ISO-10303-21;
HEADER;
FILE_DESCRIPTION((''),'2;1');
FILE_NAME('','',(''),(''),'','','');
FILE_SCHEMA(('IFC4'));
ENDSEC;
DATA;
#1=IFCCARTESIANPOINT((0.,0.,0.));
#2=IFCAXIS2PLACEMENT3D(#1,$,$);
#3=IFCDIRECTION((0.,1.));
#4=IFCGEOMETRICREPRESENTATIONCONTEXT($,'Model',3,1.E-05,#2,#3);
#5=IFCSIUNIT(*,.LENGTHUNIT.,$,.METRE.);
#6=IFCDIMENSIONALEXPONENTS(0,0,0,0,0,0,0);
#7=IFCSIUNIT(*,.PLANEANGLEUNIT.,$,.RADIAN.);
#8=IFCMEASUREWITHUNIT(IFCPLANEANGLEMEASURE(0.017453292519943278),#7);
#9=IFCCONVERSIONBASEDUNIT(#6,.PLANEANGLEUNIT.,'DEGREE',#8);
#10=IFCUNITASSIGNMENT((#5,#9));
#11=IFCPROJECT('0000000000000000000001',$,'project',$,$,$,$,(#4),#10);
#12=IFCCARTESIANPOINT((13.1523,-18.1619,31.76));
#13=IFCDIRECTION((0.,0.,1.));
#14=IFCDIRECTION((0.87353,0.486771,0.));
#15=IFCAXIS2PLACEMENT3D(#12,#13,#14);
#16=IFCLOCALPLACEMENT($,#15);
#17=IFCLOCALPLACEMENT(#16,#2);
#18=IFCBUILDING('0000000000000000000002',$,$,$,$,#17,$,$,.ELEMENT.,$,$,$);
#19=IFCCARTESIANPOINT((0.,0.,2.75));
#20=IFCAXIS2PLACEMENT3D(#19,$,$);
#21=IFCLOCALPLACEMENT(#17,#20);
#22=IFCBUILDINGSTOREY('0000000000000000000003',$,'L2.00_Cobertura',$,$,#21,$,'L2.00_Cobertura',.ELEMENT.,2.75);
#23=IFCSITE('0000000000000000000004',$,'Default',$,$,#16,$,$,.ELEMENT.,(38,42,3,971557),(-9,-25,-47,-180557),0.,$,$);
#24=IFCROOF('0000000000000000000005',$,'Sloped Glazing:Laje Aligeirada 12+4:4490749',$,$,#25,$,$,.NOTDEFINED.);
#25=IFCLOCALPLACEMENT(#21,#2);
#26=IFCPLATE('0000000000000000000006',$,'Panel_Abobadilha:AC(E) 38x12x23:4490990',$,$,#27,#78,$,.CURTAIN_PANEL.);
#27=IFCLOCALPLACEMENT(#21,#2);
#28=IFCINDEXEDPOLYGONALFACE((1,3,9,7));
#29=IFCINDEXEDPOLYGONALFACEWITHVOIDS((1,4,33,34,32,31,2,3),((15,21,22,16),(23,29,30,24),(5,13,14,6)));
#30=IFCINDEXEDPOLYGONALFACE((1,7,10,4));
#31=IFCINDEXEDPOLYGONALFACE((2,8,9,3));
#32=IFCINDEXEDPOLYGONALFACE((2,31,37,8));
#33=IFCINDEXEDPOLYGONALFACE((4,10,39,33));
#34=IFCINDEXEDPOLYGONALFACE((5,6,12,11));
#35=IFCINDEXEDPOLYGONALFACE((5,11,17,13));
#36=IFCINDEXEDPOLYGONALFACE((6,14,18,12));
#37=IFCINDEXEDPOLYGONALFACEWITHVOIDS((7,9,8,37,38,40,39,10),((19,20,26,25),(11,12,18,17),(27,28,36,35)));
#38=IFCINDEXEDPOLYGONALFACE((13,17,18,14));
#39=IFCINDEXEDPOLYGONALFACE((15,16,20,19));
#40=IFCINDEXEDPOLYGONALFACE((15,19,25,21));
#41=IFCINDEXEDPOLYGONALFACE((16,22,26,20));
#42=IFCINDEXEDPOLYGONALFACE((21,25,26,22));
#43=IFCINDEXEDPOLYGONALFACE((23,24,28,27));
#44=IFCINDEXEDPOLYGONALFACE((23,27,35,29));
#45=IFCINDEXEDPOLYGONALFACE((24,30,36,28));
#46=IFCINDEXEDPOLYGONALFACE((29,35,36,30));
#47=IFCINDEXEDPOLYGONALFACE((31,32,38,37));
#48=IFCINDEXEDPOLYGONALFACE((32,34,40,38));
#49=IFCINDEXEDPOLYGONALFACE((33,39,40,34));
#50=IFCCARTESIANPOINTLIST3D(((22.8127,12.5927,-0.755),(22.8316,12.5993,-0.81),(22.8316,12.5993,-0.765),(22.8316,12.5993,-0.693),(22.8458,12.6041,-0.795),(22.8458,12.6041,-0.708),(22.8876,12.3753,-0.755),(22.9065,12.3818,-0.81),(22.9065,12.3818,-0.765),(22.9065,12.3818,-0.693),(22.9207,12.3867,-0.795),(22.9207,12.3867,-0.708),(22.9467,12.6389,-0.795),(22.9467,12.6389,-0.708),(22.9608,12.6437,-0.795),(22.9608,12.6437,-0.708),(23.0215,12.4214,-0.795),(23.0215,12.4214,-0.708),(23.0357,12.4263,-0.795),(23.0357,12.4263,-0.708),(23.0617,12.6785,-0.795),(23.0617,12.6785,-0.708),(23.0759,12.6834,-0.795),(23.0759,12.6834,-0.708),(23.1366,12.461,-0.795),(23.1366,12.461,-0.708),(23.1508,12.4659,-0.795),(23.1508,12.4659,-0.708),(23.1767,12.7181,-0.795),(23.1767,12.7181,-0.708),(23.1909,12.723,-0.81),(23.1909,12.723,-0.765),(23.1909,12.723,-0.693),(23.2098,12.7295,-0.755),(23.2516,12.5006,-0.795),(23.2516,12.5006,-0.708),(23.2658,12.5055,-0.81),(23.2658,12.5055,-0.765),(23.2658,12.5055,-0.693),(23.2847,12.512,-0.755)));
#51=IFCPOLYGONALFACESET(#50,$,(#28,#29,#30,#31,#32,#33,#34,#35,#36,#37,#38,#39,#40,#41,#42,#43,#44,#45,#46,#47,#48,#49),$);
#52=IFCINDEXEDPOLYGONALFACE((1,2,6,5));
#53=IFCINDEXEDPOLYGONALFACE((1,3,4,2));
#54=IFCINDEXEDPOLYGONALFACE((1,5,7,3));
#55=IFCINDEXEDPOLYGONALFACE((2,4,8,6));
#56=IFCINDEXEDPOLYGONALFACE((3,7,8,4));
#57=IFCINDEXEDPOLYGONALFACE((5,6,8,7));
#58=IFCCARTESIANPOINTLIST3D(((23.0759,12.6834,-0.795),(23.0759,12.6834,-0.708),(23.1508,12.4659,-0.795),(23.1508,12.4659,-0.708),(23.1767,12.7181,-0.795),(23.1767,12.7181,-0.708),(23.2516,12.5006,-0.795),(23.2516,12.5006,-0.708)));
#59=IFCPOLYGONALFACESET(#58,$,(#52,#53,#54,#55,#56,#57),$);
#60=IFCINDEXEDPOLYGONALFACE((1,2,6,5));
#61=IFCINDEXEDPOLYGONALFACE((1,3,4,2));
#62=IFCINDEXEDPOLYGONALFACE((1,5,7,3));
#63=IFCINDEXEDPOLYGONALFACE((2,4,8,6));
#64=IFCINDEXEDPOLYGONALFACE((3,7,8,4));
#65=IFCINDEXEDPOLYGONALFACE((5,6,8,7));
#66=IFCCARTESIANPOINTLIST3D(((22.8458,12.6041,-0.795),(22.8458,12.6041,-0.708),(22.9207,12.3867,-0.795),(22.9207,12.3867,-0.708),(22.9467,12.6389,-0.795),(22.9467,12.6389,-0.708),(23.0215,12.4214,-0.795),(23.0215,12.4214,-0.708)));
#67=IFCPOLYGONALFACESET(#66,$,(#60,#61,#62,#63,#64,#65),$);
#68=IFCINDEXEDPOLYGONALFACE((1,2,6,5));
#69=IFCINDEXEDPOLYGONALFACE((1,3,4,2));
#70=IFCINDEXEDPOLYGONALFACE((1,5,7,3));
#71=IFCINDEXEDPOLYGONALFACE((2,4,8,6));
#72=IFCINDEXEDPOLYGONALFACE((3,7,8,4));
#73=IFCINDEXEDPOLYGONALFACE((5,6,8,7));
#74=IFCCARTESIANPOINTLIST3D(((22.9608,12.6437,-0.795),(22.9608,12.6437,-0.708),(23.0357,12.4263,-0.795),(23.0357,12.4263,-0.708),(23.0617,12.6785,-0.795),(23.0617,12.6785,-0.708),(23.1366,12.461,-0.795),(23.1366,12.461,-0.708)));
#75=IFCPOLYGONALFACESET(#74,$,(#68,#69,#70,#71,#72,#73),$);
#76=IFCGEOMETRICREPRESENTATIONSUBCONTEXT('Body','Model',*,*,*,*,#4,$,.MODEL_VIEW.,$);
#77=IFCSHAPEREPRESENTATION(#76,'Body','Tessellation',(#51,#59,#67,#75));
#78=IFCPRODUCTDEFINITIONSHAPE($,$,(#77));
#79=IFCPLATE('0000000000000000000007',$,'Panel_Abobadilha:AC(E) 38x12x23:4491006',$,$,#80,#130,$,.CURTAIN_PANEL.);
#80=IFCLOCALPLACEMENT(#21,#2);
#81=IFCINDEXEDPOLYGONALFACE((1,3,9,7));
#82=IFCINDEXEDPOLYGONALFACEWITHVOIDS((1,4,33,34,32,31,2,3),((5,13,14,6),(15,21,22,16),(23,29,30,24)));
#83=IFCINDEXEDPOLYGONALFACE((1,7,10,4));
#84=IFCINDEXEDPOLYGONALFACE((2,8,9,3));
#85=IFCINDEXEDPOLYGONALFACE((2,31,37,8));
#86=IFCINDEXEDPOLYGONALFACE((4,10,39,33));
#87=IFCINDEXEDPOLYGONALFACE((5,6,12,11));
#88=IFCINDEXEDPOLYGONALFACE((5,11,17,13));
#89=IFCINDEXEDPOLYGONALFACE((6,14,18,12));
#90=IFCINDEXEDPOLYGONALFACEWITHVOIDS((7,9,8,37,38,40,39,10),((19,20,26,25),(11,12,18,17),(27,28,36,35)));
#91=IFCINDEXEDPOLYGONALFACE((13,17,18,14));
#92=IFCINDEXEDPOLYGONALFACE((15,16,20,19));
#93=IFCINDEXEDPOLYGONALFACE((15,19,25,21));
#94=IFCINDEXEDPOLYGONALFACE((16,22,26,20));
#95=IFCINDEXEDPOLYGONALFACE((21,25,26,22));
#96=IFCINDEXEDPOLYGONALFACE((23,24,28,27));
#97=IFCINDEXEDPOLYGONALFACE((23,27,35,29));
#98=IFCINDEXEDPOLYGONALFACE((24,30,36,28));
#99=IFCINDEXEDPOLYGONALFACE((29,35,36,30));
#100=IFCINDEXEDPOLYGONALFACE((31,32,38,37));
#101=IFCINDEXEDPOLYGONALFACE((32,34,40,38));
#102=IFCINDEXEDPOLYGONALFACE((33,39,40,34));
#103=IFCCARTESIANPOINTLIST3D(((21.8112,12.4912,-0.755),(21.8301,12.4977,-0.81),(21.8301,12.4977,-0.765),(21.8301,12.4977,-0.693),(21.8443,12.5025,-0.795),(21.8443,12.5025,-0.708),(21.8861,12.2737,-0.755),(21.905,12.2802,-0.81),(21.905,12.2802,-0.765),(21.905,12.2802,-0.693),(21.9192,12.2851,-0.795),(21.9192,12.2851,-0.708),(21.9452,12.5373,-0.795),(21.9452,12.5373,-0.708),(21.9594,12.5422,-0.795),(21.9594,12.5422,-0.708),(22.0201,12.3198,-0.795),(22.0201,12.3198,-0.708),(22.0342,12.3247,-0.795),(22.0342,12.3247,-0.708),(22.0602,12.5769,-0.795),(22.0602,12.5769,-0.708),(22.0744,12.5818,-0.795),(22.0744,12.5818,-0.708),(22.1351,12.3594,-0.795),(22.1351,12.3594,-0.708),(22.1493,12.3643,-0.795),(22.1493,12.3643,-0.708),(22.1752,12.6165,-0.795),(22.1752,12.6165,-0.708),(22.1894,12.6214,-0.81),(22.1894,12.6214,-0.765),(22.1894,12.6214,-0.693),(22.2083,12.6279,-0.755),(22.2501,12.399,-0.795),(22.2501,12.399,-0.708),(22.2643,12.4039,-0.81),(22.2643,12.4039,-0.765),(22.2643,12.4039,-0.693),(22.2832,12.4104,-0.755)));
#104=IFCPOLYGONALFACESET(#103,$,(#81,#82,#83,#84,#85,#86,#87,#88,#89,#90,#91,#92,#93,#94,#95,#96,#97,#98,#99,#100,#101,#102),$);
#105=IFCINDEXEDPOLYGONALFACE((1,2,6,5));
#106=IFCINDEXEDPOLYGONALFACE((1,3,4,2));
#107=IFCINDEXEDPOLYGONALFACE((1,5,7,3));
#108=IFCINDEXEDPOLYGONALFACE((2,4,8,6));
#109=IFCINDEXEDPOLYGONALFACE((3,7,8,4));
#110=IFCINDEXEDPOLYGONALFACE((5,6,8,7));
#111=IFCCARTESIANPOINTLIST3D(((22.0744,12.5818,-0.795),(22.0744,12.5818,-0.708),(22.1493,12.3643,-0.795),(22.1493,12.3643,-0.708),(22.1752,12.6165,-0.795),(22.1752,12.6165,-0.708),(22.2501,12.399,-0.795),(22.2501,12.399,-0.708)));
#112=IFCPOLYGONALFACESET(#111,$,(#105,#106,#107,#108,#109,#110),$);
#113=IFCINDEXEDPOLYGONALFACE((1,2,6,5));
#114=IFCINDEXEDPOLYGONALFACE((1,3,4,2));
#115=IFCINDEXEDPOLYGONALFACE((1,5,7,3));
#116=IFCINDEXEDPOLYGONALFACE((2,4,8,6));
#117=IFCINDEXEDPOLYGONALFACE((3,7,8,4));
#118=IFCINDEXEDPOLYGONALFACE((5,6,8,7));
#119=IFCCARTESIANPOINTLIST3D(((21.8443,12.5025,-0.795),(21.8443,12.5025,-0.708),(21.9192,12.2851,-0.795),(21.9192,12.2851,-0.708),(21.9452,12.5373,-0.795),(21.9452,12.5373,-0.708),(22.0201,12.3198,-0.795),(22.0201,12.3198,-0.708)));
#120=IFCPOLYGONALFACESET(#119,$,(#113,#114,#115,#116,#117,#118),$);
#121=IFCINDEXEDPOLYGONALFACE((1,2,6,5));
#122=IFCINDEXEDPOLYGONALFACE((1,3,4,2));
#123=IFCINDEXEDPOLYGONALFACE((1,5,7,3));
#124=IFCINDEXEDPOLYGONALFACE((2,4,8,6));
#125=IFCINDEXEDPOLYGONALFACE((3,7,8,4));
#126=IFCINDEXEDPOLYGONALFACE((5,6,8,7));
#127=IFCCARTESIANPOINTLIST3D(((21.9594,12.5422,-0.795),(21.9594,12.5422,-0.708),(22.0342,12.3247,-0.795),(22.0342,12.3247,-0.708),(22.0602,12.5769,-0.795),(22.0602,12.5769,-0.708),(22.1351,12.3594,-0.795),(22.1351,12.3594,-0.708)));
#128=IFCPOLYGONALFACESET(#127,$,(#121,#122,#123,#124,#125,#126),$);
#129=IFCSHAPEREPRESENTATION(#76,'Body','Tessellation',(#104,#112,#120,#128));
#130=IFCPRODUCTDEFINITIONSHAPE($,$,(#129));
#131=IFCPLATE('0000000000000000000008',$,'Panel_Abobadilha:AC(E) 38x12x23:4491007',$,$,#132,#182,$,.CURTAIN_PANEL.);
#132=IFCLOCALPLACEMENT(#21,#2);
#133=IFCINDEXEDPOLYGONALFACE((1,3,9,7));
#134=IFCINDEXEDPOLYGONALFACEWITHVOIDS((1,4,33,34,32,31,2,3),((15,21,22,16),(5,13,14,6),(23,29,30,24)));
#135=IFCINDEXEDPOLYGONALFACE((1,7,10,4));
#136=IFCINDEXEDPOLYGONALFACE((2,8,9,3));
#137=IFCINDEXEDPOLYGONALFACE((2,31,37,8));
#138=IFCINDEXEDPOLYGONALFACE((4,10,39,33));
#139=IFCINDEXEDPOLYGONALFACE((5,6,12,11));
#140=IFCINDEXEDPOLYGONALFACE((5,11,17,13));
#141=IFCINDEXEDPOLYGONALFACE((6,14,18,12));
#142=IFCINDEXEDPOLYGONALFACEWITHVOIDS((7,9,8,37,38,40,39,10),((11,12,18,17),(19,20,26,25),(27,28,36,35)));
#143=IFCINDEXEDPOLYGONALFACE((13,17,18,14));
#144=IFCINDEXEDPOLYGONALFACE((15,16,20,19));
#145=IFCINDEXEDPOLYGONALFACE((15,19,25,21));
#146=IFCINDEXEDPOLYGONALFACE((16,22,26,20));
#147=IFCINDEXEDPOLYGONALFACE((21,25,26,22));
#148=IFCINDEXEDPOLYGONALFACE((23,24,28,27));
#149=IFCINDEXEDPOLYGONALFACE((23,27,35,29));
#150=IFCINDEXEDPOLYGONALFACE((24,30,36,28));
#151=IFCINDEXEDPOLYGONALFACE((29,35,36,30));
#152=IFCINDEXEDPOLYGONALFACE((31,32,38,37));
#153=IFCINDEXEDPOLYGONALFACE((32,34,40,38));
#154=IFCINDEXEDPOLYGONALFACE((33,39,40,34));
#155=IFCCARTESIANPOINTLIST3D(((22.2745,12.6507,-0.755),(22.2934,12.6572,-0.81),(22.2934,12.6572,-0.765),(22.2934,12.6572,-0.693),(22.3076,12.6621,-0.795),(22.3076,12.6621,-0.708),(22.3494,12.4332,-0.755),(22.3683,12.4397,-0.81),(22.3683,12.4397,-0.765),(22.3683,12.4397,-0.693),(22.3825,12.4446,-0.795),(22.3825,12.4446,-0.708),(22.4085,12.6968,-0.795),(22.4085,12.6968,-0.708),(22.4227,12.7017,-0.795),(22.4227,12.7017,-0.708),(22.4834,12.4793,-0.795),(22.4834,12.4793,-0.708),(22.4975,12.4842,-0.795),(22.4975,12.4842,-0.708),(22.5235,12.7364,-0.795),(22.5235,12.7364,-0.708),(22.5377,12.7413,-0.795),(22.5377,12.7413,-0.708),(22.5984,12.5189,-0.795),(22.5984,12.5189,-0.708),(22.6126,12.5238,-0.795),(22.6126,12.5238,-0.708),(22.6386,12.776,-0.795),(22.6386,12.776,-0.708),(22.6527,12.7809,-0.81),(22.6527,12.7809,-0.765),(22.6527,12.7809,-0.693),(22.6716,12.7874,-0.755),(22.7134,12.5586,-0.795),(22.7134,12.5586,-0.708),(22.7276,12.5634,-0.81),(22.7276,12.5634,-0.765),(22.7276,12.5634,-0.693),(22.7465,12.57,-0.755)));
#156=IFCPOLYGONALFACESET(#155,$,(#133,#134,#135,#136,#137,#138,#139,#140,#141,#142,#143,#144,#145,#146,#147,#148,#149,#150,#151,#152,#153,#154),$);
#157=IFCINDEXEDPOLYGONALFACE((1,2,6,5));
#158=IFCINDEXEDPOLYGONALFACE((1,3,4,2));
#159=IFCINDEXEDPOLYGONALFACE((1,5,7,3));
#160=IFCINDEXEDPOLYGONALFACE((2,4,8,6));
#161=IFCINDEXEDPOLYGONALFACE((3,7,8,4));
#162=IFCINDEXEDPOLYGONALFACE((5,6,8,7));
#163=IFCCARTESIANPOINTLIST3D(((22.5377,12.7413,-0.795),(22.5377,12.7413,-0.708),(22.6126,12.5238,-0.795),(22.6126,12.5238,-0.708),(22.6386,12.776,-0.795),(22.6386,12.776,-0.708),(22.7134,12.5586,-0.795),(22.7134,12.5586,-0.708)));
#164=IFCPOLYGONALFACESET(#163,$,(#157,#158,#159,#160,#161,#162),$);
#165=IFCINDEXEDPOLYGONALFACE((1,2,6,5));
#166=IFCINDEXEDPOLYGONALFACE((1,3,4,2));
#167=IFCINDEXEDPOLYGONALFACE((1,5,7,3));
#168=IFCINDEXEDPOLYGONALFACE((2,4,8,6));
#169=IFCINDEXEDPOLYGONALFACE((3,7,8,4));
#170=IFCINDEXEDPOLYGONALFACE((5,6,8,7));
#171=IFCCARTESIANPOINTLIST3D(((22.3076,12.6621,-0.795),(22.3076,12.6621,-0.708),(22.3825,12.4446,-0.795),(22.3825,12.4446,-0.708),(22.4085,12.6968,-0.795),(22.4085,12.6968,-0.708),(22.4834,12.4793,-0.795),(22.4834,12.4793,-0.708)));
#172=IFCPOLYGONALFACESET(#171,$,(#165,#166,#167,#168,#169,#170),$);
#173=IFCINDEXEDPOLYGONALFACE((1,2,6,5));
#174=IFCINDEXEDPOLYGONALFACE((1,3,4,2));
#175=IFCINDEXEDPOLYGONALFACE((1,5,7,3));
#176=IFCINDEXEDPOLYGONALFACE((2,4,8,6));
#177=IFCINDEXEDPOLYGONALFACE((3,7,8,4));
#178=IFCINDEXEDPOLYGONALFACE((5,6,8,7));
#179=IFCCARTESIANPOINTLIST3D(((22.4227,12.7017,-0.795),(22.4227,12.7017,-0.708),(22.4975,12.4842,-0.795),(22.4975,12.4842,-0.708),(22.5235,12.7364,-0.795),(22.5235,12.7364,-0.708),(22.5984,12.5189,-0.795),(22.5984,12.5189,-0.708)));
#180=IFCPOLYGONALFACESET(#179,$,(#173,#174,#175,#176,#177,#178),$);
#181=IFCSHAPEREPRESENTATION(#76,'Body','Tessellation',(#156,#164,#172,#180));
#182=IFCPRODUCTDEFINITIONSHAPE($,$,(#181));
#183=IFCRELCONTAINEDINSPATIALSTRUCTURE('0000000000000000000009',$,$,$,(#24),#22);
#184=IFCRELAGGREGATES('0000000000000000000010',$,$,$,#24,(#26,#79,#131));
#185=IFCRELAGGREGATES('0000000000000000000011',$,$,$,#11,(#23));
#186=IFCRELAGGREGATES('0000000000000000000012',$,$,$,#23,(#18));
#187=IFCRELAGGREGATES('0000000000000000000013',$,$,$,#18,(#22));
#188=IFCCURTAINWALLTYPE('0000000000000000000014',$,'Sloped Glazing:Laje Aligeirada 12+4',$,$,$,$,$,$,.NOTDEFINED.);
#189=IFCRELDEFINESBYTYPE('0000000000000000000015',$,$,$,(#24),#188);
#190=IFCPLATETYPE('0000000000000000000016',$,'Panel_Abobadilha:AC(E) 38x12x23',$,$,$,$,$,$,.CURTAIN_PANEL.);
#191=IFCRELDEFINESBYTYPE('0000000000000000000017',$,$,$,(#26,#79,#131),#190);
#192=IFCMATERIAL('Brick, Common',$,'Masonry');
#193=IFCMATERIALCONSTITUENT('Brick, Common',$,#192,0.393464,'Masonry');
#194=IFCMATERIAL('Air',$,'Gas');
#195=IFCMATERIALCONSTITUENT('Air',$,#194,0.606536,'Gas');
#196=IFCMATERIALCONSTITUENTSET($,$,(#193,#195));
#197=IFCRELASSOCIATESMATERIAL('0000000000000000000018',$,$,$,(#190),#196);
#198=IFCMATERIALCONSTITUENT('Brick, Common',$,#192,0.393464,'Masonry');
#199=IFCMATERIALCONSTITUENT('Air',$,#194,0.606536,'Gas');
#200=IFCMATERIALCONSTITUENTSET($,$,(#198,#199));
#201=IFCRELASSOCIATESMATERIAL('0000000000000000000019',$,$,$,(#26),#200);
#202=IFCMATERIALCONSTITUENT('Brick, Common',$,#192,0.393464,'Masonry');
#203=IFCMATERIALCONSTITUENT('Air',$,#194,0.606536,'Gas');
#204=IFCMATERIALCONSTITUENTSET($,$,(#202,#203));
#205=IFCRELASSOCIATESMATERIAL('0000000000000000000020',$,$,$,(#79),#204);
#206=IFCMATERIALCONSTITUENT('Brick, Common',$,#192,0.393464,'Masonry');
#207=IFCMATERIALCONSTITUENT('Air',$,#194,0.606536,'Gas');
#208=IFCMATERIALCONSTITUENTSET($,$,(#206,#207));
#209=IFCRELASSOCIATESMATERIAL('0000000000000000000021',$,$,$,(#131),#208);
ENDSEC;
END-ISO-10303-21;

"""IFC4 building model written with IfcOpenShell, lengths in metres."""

from ifc_helpers import new_model, entity, si_unit, converted_unit, direction, frame, origin, place, context, subcontext, project, spatial, indexed_curve, outline, extrude, source, transform, mapped, material, constituent, constituent_set, type_object, type_shapes, element, aggregate, save


model = new_model("IFC4")

# Units and contexts
model_context = context("Model", 3, precision=1e-05, world=origin(), true_north=direction((0.0, 1.0)))
body_context = subcontext(model_context, "Body", "Model", "MODEL_VIEW")
ifc_project = project(units=[si_unit("LENGTHUNIT", "METRE"), converted_unit("PLANEANGLEUNIT", "DEGREE", entity("IfcPlaneAngleMeasure", 0.017453292519943278), si_unit("PLANEANGLEUNIT", "RADIAN"), dimensions=[0, 0, 0, 0, 0, 0, 0])], contexts=[model_context])

# Site, building, storey
site_placement = place(None, frame((13.1523, -18.1619, 31.76), z_axis=(0.0, 0.0, 1.0), x_axis=(0.87353, 0.486771, 0.0)))
site = spatial("IfcSite", under=ifc_project, at=site_placement, Name="Default", CompositionType="ELEMENT", RefLatitude=(38, 42, 3, 971557), RefLongitude=(-9, -25, -47, -180557), RefElevation=0.0)
building_placement = place(site_placement, origin())
building = spatial("IfcBuilding", under=site, at=building_placement, CompositionType="ELEMENT")
storey_placement = place(building_placement, frame((0.0, 0.0, 2.75)))
storey = spatial("IfcBuildingStorey", under=building, at=storey_placement, Name="L2.00_Cobertura", LongName="L2.00_Cobertura", CompositionType="ELEMENT", Elevation=2.75)

# Roof, plates
curtain_wall_type = type_object("IfcCurtainWallType", Name="Sloped Glazing:Laje Aligeirada 12+4", PredefinedType="NOTDEFINED")
roof_placement = place(storey_placement, frame((0.0, 0.0, -2.75)))
roof = element("IfcRoof", 1, at=roof_placement, inside=storey, type_object=curtain_wall_type, Name="Sloped Glazing:Laje Aligeirada 12+4:4490749", PredefinedType="NOTDEFINED")
ifc_material_1 = material(Name="Brick, Common", Category="Masonry")
ifc_material_2 = material(Name="Air", Category="Gas")
ifc_constituent_1 = constituent(ifc_material_1, Name="Brick, Common", Category="Masonry", fraction=0.393464)
ifc_constituent_2 = constituent(ifc_material_2, Name="Air", Category="Gas", fraction=0.606536)
ifc_constituent_set_1 = constituent_set(constituents=[ifc_constituent_1, ifc_constituent_2])
plate_type = type_object("IfcPlateType", Name="Panel_Abobadilha:AC(E) 38x12x23", PredefinedType="CURTAIN_PANEL", material=ifc_constituent_set_1)
shared_shape_1 = source(origin(), body_context, "Body", "SweptSolid", [
    extrude(outline(indexed_curve([(-0.19, -0.0543), (0.19, -0.0543), (0.19, -0.0093), (0.21, 0.0007), (0.19, 0.0628), (-0.19, 0.0628), (-0.21, 0.0007), (-0.19, -0.0093), (-0.19, -0.0543)], self_intersect=False), holes=[indexed_curve([(-0.0683, 0.0477), (-0.0683, -0.0393), (-0.175, -0.0393), (-0.175, 0.0477), (-0.0683, 0.0477)], self_intersect=False), indexed_curve([(0.0533, 0.0477), (0.0533, -0.0393), (-0.0533, -0.0393), (-0.0533, 0.0477), (0.0533, 0.0477)], self_intersect=False), indexed_curve([(0.175, 0.0477), (0.175, -0.0393), (0.0683, -0.0393), (0.0683, 0.0477), (0.175, 0.0477)], self_intersect=False)]), frame((0.0, 0.0543, 0.0)), (0.0, 0.0, 1.0), 0.23),
    extrude(outline(indexed_curve([(-0.0533, -0.0435), (0.0533, -0.0435), (0.0533, 0.0435), (-0.0533, 0.0435), (-0.0533, -0.0435)], self_intersect=False)), frame((0.1217, 0.0585, 0.0), z_axis=(0.0, 0.0, 1.0), x_axis=(-1.0, 0.0, 0.0)), (0.0, 0.0, 1.0), 0.23),
    extrude(outline(indexed_curve([(-0.0533, -0.0435), (0.0533, -0.0435), (0.0533, 0.0435), (-0.0533, 0.0435), (-0.0533, -0.0435)], self_intersect=False)), frame((-0.1217, 0.0585, 0.0), z_axis=(0.0, 0.0, 1.0), x_axis=(-1.0, 0.0, 0.0)), (0.0, 0.0, 1.0), 0.23),
    extrude(outline(indexed_curve([(-0.0533, -0.0435), (0.0533, -0.0435), (0.0533, 0.0435), (-0.0533, 0.0435), (-0.0533, -0.0435)], self_intersect=False)), frame((0.0, 0.0585, 0.0), z_axis=(0.0, 0.0, 1.0), x_axis=(-1.0, 0.0, 0.0)), (0.0, 0.0, 1.0), 0.23),
])
type_shapes(plate_type, [shared_shape_1])
ifc_constituent_3 = constituent(ifc_material_1, Name="Brick, Common", Category="Masonry", fraction=0.393464)
ifc_constituent_4 = constituent(ifc_material_2, Name="Air", Category="Gas", fraction=0.606536)
ifc_constituent_set_2 = constituent_set(constituents=[ifc_constituent_3, ifc_constituent_4])
plate_1_placement = place(roof_placement, frame((23.0113, 12.6611, 1.94), z_axis=(0.325568, -0.945519, 0.0), x_axis=(0.945519, 0.325568, 0.0)))
plate_1 = element("IfcPlate", 2, at=plate_1_placement, type_object=plate_type, material=ifc_constituent_set_2, Name="Panel_Abobadilha:AC(E) 38x12x23:4490990", PredefinedType="CURTAIN_PANEL", context=body_context, shape_type="MappedRepresentation", body=[
    mapped(shared_shape_1, transform((0.0, 0.0, 0.0), scale=1.0)),
])
ifc_constituent_5 = constituent(ifc_material_1, Name="Brick, Common", Category="Masonry", fraction=0.393464)
ifc_constituent_6 = constituent(ifc_material_2, Name="Air", Category="Gas", fraction=0.606536)
ifc_constituent_set_3 = constituent_set(constituents=[ifc_constituent_5, ifc_constituent_6])
plate_2_placement = place(roof_placement, frame((22.0098, 12.5595, 1.94), z_axis=(0.325568, -0.945519, 0.0), x_axis=(0.945519, 0.325568, 0.0)))
plate_2 = element("IfcPlate", 3, at=plate_2_placement, type_object=plate_type, material=ifc_constituent_set_3, Name="Panel_Abobadilha:AC(E) 38x12x23:4491006", PredefinedType="CURTAIN_PANEL", context=body_context, shape_type="MappedRepresentation", body=[
    mapped(shared_shape_1, transform((0.0, 0.0, 0.0), scale=1.0)),
])
ifc_constituent_7 = constituent(ifc_material_1, Name="Brick, Common", Category="Masonry", fraction=0.393464)
ifc_constituent_8 = constituent(ifc_material_2, Name="Air", Category="Gas", fraction=0.606536)
ifc_constituent_set_4 = constituent_set(constituents=[ifc_constituent_7, ifc_constituent_8])
plate_3_placement = place(roof_placement, frame((22.4731, 12.7191, 1.94), z_axis=(0.325568, -0.945519, 0.0), x_axis=(0.945519, 0.325568, 0.0)))
plate_3 = element("IfcPlate", 4, at=plate_3_placement, type_object=plate_type, material=ifc_constituent_set_4, Name="Panel_Abobadilha:AC(E) 38x12x23:4491007", PredefinedType="CURTAIN_PANEL", context=body_context, shape_type="MappedRepresentation", body=[
    mapped(shared_shape_1, transform((0.0, 0.0, 0.0), scale=1.0)),
])
aggregate(roof, [plate_1, plate_2, plate_3])

save(model, "model.ifc")
